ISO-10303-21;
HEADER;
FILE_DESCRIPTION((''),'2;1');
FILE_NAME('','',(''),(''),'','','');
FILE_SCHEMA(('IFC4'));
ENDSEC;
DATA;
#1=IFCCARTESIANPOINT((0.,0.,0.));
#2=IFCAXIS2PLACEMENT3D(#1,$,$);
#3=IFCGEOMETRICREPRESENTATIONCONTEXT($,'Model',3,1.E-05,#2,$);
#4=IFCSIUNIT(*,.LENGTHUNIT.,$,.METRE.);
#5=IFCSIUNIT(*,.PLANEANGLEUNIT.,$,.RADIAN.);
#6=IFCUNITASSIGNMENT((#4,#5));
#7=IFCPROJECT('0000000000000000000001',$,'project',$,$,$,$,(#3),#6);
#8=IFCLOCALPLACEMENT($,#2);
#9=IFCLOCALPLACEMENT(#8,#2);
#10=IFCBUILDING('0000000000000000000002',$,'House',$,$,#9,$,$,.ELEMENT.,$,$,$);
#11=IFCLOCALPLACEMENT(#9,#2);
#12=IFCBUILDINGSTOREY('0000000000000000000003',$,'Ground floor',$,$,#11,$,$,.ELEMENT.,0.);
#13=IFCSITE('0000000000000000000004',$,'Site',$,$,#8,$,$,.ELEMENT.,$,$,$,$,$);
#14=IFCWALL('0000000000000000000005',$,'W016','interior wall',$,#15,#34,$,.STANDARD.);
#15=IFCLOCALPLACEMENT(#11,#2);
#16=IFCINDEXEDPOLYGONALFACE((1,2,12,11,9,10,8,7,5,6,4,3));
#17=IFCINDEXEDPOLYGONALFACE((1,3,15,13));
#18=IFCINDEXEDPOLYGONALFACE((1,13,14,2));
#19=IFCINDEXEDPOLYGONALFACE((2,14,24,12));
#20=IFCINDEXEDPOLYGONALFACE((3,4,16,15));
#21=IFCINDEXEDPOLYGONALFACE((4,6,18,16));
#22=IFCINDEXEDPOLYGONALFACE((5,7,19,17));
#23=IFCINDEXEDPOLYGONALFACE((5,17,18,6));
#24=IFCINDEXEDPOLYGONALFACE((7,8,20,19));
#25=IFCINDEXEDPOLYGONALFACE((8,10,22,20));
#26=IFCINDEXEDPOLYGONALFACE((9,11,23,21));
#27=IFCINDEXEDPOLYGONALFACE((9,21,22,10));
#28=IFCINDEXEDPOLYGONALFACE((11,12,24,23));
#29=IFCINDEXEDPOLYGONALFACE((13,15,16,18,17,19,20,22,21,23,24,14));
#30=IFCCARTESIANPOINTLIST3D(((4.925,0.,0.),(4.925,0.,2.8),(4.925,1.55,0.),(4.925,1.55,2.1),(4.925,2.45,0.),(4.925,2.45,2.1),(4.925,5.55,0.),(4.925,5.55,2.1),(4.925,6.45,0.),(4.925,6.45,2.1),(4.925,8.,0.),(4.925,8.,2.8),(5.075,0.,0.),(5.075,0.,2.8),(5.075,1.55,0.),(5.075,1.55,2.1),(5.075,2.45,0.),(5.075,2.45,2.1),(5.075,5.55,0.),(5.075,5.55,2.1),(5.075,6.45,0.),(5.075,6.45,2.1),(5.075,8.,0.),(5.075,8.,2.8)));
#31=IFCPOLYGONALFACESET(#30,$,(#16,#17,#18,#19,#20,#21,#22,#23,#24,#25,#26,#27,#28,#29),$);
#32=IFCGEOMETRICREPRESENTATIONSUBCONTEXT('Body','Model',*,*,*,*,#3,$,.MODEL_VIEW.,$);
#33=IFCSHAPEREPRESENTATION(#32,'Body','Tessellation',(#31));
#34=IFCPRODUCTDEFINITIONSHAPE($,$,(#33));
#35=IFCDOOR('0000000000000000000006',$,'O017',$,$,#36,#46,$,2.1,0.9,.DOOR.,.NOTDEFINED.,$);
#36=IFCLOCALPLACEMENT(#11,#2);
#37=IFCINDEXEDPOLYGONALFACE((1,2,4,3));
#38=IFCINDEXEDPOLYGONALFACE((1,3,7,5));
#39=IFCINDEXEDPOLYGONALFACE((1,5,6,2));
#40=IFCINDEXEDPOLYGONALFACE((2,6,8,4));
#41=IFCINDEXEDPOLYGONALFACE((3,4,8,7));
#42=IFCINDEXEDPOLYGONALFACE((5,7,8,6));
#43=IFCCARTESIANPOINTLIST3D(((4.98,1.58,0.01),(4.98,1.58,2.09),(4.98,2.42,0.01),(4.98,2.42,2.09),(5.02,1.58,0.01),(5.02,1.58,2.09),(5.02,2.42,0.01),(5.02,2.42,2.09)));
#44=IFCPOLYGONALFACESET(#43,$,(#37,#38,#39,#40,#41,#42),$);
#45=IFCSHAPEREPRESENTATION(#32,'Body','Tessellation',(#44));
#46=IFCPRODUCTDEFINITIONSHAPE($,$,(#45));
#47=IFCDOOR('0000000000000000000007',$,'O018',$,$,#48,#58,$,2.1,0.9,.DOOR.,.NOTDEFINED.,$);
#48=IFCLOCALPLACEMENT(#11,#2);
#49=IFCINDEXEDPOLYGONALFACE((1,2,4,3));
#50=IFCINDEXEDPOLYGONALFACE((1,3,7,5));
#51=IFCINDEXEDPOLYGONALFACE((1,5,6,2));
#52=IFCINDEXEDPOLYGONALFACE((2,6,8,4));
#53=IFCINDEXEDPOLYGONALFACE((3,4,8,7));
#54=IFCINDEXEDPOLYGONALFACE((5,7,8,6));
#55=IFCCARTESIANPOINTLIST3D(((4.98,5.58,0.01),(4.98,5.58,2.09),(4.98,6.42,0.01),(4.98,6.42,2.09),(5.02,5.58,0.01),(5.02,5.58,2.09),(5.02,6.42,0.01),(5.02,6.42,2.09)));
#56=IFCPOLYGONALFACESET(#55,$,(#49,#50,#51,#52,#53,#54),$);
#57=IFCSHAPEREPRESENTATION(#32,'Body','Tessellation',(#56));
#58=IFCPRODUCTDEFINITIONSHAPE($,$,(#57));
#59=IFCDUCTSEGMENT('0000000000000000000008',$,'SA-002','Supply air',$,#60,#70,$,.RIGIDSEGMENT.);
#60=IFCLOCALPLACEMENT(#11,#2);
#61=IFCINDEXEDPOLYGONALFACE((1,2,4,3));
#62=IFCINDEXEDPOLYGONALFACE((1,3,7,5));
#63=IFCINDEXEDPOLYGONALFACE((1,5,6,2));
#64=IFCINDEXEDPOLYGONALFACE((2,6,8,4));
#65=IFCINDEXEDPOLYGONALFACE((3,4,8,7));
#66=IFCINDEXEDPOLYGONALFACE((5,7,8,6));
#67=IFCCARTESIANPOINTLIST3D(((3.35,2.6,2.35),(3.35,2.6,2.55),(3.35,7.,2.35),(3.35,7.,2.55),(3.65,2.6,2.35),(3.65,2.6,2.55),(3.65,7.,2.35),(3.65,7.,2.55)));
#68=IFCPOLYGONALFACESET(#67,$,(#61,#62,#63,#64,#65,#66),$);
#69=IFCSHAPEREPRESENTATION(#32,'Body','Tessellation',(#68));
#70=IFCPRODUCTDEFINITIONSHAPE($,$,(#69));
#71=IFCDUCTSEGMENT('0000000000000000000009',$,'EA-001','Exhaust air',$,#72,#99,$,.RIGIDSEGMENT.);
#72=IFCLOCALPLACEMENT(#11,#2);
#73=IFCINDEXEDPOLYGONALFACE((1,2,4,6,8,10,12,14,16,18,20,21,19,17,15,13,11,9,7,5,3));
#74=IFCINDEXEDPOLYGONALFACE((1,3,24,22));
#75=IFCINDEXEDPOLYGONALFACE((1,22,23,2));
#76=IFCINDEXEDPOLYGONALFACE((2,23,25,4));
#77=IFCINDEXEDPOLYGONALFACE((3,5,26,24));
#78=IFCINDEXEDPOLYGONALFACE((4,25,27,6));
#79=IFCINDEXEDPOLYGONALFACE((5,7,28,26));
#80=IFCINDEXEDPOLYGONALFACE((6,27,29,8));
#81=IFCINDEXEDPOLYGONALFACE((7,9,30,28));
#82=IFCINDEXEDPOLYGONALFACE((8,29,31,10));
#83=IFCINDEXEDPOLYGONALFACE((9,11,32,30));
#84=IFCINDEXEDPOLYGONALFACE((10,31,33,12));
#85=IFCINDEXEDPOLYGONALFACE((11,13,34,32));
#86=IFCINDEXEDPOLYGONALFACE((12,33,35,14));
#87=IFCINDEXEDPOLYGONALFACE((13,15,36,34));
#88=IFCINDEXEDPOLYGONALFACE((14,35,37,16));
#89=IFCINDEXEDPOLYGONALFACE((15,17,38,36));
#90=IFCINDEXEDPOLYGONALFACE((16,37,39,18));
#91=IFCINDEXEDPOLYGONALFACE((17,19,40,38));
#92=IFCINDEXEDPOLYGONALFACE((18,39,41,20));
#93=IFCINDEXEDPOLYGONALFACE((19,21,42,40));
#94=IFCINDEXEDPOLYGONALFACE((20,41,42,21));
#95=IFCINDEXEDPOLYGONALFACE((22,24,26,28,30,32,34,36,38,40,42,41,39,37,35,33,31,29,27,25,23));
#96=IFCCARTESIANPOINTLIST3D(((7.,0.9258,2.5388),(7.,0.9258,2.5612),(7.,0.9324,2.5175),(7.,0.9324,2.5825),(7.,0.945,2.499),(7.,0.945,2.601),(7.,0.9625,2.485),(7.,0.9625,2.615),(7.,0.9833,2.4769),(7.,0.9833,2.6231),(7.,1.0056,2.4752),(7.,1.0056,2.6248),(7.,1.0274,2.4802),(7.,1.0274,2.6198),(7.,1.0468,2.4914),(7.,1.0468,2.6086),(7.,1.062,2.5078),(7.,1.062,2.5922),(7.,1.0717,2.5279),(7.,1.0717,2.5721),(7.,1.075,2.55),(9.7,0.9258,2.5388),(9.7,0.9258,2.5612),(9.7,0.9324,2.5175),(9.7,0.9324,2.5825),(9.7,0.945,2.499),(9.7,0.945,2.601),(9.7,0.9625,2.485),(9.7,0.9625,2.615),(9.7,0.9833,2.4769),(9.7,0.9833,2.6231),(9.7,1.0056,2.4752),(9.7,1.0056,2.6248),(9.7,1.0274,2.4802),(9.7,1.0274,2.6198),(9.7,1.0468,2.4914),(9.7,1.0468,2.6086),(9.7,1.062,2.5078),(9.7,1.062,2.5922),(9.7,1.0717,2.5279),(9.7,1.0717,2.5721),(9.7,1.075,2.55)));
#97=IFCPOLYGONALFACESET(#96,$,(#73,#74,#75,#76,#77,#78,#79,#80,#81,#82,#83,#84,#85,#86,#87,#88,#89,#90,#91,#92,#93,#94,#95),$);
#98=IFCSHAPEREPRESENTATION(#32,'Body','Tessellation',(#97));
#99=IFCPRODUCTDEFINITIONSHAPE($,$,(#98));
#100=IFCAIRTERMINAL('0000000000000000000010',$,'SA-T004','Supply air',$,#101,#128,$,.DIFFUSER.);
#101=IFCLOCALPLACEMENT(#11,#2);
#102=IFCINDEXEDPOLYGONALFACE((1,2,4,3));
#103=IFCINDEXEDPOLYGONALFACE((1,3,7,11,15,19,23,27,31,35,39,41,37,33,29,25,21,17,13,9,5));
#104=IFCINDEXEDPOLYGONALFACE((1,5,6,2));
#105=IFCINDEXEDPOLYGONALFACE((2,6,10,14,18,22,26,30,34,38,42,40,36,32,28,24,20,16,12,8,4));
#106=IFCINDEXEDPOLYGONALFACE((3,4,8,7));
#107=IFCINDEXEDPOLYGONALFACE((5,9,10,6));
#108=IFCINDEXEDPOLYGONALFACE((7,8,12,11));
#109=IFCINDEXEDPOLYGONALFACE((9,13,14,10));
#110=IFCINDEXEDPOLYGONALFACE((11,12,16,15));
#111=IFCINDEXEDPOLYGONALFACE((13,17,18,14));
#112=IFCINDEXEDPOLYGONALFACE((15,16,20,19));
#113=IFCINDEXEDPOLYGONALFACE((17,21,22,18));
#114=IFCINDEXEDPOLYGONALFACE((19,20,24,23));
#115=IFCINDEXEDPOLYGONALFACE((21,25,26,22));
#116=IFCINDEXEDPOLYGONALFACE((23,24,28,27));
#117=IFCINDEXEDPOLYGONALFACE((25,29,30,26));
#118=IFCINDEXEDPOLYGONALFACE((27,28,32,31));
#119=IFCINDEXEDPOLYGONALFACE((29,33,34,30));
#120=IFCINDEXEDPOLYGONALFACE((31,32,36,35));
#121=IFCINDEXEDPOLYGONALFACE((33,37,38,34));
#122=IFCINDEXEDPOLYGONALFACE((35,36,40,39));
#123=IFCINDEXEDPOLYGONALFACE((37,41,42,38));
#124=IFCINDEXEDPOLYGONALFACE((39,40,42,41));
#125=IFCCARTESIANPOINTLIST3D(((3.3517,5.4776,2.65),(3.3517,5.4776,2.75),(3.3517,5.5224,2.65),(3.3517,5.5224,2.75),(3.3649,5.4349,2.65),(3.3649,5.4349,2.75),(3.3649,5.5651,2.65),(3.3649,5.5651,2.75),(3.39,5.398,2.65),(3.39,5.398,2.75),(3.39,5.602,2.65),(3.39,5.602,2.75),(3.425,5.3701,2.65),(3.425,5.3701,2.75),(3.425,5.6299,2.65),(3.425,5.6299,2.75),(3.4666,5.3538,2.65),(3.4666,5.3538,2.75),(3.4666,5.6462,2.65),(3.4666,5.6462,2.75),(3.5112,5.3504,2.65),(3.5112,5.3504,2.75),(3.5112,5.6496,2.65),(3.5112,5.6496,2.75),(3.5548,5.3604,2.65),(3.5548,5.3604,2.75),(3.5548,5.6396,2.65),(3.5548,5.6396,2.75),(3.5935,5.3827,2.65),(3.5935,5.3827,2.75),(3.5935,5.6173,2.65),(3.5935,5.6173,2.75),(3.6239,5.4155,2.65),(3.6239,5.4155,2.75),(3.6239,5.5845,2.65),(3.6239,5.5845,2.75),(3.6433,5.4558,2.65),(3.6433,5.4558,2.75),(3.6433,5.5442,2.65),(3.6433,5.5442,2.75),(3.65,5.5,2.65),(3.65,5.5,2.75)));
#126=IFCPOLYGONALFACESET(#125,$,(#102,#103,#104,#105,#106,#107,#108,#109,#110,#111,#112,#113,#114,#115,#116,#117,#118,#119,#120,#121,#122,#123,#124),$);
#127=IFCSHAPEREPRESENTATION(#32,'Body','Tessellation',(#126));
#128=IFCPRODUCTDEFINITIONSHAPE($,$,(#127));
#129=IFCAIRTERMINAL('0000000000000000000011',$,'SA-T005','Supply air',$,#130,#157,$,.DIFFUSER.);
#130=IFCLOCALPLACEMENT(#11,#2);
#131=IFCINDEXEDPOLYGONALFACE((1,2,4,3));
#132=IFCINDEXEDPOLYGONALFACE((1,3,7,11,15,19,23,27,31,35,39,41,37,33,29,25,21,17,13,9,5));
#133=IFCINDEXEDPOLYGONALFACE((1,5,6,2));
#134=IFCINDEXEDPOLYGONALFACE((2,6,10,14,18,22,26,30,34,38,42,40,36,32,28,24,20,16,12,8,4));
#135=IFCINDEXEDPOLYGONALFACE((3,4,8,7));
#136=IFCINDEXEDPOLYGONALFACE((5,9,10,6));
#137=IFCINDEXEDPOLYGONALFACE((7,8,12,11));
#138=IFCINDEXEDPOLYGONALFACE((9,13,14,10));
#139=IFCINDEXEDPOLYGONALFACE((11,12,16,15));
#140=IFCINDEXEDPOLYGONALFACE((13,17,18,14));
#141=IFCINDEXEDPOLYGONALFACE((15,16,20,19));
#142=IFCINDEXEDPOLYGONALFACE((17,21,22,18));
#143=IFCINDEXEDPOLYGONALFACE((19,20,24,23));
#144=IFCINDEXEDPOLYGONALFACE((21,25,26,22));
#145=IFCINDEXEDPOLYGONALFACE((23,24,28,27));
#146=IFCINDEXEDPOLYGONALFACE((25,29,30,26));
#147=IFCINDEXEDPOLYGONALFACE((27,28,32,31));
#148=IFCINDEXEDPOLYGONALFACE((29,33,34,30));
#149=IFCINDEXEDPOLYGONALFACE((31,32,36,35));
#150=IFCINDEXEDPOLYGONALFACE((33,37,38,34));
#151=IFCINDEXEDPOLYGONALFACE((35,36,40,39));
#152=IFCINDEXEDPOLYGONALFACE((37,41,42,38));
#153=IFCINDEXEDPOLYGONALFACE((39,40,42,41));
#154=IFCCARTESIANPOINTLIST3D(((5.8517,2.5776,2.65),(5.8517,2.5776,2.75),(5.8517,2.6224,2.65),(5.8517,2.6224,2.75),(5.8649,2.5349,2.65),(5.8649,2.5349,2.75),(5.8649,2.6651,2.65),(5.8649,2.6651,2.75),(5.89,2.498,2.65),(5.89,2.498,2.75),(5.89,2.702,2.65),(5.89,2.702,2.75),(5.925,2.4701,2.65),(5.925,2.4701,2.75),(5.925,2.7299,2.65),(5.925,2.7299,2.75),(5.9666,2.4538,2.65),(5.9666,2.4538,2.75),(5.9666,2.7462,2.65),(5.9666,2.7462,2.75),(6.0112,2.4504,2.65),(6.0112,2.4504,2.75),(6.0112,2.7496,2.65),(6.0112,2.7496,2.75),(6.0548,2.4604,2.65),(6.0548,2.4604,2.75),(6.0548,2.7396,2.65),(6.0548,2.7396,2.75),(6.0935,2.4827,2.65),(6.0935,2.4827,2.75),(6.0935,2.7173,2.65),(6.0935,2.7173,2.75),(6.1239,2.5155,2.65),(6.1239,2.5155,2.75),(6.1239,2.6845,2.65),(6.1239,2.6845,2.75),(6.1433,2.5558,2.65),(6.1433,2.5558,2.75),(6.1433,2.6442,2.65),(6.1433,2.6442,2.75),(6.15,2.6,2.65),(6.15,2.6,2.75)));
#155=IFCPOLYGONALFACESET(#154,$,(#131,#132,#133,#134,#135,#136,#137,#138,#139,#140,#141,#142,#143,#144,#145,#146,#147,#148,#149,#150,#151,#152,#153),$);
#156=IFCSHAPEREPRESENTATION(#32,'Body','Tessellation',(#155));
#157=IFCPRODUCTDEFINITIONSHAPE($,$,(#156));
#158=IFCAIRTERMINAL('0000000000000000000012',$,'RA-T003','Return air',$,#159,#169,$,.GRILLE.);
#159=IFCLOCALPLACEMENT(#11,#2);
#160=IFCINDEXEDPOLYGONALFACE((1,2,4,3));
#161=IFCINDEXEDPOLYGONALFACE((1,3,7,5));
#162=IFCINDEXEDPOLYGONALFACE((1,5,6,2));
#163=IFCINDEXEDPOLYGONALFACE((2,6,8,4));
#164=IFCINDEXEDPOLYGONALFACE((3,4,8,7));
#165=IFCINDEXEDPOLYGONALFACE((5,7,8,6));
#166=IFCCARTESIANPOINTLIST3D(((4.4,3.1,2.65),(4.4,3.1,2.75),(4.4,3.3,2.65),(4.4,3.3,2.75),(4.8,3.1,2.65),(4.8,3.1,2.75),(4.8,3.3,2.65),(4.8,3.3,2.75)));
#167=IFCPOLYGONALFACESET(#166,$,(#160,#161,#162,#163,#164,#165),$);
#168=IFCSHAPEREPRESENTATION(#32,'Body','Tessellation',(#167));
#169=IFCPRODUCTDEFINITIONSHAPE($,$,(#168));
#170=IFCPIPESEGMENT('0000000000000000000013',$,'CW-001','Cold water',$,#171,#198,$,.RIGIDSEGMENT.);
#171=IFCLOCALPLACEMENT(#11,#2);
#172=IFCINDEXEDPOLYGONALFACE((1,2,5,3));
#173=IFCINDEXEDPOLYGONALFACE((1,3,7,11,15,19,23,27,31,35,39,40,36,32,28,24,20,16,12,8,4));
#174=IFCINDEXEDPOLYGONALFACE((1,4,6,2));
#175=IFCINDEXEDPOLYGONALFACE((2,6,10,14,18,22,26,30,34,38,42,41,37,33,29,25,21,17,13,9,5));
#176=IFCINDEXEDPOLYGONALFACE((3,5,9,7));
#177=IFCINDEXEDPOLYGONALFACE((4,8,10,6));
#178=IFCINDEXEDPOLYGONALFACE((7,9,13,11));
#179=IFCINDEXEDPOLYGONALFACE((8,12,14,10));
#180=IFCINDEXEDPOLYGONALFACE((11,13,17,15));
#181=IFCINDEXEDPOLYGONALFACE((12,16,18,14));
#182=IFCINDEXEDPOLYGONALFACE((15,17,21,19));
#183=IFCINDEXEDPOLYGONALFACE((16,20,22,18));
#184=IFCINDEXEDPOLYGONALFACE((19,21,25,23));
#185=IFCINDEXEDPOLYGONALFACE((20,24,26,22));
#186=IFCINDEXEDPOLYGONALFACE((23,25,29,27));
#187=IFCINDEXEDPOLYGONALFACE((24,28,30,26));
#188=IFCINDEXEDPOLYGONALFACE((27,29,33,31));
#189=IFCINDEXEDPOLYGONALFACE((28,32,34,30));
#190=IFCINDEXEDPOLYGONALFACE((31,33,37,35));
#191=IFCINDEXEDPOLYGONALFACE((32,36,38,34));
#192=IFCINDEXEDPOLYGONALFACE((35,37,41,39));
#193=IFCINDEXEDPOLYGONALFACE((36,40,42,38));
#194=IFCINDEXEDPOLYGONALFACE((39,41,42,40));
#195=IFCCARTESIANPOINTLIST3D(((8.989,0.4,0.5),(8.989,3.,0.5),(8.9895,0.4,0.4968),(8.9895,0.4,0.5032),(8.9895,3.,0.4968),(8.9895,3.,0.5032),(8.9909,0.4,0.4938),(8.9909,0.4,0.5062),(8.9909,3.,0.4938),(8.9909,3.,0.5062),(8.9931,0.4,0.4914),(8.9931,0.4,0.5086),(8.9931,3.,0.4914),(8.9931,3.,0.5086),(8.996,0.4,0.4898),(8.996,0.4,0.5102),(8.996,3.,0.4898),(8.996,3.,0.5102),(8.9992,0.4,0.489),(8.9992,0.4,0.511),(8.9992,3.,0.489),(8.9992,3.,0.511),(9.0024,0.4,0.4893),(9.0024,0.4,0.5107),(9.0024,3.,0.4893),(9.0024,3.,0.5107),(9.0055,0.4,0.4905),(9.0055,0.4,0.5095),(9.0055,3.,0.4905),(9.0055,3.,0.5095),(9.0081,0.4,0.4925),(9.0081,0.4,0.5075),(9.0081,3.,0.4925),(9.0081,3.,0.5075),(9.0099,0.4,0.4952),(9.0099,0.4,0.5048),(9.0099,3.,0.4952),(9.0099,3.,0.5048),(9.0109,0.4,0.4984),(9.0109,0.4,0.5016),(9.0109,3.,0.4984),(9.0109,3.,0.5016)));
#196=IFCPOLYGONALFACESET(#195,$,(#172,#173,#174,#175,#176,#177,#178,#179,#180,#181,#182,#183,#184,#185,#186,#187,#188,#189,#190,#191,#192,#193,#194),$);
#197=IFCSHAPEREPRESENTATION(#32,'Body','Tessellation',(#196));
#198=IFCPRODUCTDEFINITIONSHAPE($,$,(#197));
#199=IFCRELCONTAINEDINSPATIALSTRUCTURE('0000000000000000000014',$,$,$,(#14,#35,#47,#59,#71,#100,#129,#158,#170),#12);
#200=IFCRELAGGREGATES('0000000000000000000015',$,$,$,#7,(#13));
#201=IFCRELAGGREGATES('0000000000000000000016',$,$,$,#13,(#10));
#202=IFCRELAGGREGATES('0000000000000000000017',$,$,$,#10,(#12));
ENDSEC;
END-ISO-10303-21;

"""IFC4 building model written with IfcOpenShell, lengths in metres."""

from ifc_helpers import new_model, si_unit, frame, origin, origin_2d, place, context, subcontext, project, spatial, rectangle, circle, extrude, element, fill, save


model = new_model("IFC4")

# Units and contexts
model_context = context("Model", 3, precision=1e-05, world=origin())
body_context = subcontext(model_context, "Body", "Model", "MODEL_VIEW")
ifc_project = project(units=[si_unit("LENGTHUNIT", "METRE"), si_unit("PLANEANGLEUNIT", "RADIAN")], contexts=[model_context])

# Site, building, storey
site_placement = place(None, origin())
site = spatial("IfcSite", under=ifc_project, at=site_placement, Name="Site", CompositionType="ELEMENT")
building_placement = place(site_placement, origin())
building = spatial("IfcBuilding", under=site, at=building_placement, Name="House", CompositionType="ELEMENT")
storey_placement = place(building_placement, origin())
storey = spatial("IfcBuildingStorey", under=building, at=storey_placement, Name="Ground floor", CompositionType="ELEMENT", Elevation=0.0)

# Wall, openings, doors
wall_1_placement = place(storey_placement, frame((5.0, 4.0, 0.0), z_axis=(0.0, 0.0, 1.0), x_axis=(0.0, 1.0, 0.0)))
wall_1 = element("IfcWall", 1, at=wall_1_placement, inside=storey, Name="W016", Description="interior wall", PredefinedType="STANDARD", context=body_context, shape_type="SweptSolid", body=[
    extrude(rectangle(XDim=8.0, YDim=0.15, at=origin_2d()), origin(), (0.0, 0.0, 1.0), 2.8),
])
opening_1_placement = place(wall_1_placement, frame((-2.0, 0.0, 0.0)))
opening_1 = element("IfcOpeningElement", 2, at=opening_1_placement, cuts=wall_1, PredefinedType="OPENING", context=body_context, shape_type="SweptSolid", body=[
    extrude(rectangle(XDim=0.9, YDim=0.18, at=origin_2d()), origin(), (0.0, 0.0, 1.0), 2.1),
])
opening_2_placement = place(wall_1_placement, frame((2.0, 0.0, 0.0)))
opening_2 = element("IfcOpeningElement", 3, at=opening_2_placement, cuts=wall_1, PredefinedType="OPENING", context=body_context, shape_type="SweptSolid", body=[
    extrude(rectangle(XDim=0.9, YDim=0.18, at=origin_2d()), origin(), (0.0, 0.0, 1.0), 2.1),
])
door_1_placement = place(wall_1_placement, frame((-2.0, 0.0, 0.0)))
door_1 = element("IfcDoor", 4, at=door_1_placement, inside=storey, Name="O017", OperationType="NOTDEFINED", OverallHeight=2.1, OverallWidth=0.9, PredefinedType="DOOR", context=body_context, shape_type="SweptSolid", body=[
    extrude(rectangle(XDim=0.84, YDim=0.04, at=origin_2d()), frame((0.0, 0.0, 0.01)), (0.0, 0.0, 1.0), 2.08),
])
fill(opening_1, door_1)
door_2_placement = place(wall_1_placement, frame((2.0, 0.0, 0.0)))
door_2 = element("IfcDoor", 5, at=door_2_placement, inside=storey, Name="O018", OperationType="NOTDEFINED", OverallHeight=2.1, OverallWidth=0.9, PredefinedType="DOOR", context=body_context, shape_type="SweptSolid", body=[
    extrude(rectangle(XDim=0.84, YDim=0.04, at=origin_2d()), frame((0.0, 0.0, 0.01)), (0.0, 0.0, 1.0), 2.08),
])
fill(opening_2, door_2)

# Duct segments
duct_segment_1_placement = place(storey_placement, frame((3.5, 2.6, 2.45), z_axis=(0.0, 1.0, 0.0), x_axis=(-1.0, 0.0, 0.0)))
element("IfcDuctSegment", 6, at=duct_segment_1_placement, inside=storey, Name="SA-002", Description="Supply air", PredefinedType="RIGIDSEGMENT", context=body_context, shape_type="SweptSolid", body=[
    extrude(rectangle(XDim=0.3, YDim=0.2, at=origin_2d()), origin(), (0.0, 0.0, 1.0), 4.4),
])
duct_segment_2_placement = place(storey_placement, frame((7.0, 1.0, 2.55), z_axis=(1.0, 0.0, 0.0), x_axis=(0.0, 1.0, 0.0)))
element("IfcDuctSegment", 7, at=duct_segment_2_placement, inside=storey, Name="EA-001", Description="Exhaust air", PredefinedType="RIGIDSEGMENT", context=body_context, shape_type="SweptSolid", body=[
    extrude(circle(Radius=0.075, at=origin_2d()), origin(), (0.0, 0.0, 1.0), 2.7),
])

# Air terminals
for number, where, z_axis, x_axis, name in (
    (8, (3.5, 5.5, 2.65), (0.0, 0.0, 1.0), (1.0, 0.0, 0.0), "SA-T004"),
    (9, (6.0, 2.6, 2.65), (0.0, 0.0, 1.0), (1.0, 0.0, 0.0), "SA-T005"),
):
    element("IfcAirTerminal", number, at=place(storey_placement, frame(where, z_axis=z_axis, x_axis=x_axis)), inside=storey, Name=name, Description="Supply air", PredefinedType="DIFFUSER", context=body_context, shape_type="SweptSolid", body=[
        extrude(circle(Radius=0.15, at=origin_2d()), origin(), (0.0, 0.0, 1.0), 0.1),
    ])
air_terminal_placement = place(storey_placement, frame((4.6, 3.2, 2.65), z_axis=(0.0, 0.0, 1.0), x_axis=(1.0, 0.0, 0.0)))
element("IfcAirTerminal", 10, at=air_terminal_placement, inside=storey, Name="RA-T003", Description="Return air", PredefinedType="GRILLE", context=body_context, shape_type="SweptSolid", body=[
    extrude(rectangle(XDim=0.4, YDim=0.2, at=origin_2d()), origin(), (0.0, 0.0, 1.0), 0.1),
])

# Pipe segment
pipe_segment_1_placement = place(storey_placement, frame((9.0, 0.4, 0.5), z_axis=(0.0, 1.0, 0.0), x_axis=(-1.0, 0.0, 0.0)))
element("IfcPipeSegment", 11, at=pipe_segment_1_placement, inside=storey, Name="CW-001", Description="Cold water", PredefinedType="RIGIDSEGMENT", context=body_context, shape_type="SweptSolid", body=[
    extrude(circle(Radius=0.011, at=origin_2d()), origin(), (0.0, 0.0, 1.0), 2.6),
])

save(model, "model.ifc")
